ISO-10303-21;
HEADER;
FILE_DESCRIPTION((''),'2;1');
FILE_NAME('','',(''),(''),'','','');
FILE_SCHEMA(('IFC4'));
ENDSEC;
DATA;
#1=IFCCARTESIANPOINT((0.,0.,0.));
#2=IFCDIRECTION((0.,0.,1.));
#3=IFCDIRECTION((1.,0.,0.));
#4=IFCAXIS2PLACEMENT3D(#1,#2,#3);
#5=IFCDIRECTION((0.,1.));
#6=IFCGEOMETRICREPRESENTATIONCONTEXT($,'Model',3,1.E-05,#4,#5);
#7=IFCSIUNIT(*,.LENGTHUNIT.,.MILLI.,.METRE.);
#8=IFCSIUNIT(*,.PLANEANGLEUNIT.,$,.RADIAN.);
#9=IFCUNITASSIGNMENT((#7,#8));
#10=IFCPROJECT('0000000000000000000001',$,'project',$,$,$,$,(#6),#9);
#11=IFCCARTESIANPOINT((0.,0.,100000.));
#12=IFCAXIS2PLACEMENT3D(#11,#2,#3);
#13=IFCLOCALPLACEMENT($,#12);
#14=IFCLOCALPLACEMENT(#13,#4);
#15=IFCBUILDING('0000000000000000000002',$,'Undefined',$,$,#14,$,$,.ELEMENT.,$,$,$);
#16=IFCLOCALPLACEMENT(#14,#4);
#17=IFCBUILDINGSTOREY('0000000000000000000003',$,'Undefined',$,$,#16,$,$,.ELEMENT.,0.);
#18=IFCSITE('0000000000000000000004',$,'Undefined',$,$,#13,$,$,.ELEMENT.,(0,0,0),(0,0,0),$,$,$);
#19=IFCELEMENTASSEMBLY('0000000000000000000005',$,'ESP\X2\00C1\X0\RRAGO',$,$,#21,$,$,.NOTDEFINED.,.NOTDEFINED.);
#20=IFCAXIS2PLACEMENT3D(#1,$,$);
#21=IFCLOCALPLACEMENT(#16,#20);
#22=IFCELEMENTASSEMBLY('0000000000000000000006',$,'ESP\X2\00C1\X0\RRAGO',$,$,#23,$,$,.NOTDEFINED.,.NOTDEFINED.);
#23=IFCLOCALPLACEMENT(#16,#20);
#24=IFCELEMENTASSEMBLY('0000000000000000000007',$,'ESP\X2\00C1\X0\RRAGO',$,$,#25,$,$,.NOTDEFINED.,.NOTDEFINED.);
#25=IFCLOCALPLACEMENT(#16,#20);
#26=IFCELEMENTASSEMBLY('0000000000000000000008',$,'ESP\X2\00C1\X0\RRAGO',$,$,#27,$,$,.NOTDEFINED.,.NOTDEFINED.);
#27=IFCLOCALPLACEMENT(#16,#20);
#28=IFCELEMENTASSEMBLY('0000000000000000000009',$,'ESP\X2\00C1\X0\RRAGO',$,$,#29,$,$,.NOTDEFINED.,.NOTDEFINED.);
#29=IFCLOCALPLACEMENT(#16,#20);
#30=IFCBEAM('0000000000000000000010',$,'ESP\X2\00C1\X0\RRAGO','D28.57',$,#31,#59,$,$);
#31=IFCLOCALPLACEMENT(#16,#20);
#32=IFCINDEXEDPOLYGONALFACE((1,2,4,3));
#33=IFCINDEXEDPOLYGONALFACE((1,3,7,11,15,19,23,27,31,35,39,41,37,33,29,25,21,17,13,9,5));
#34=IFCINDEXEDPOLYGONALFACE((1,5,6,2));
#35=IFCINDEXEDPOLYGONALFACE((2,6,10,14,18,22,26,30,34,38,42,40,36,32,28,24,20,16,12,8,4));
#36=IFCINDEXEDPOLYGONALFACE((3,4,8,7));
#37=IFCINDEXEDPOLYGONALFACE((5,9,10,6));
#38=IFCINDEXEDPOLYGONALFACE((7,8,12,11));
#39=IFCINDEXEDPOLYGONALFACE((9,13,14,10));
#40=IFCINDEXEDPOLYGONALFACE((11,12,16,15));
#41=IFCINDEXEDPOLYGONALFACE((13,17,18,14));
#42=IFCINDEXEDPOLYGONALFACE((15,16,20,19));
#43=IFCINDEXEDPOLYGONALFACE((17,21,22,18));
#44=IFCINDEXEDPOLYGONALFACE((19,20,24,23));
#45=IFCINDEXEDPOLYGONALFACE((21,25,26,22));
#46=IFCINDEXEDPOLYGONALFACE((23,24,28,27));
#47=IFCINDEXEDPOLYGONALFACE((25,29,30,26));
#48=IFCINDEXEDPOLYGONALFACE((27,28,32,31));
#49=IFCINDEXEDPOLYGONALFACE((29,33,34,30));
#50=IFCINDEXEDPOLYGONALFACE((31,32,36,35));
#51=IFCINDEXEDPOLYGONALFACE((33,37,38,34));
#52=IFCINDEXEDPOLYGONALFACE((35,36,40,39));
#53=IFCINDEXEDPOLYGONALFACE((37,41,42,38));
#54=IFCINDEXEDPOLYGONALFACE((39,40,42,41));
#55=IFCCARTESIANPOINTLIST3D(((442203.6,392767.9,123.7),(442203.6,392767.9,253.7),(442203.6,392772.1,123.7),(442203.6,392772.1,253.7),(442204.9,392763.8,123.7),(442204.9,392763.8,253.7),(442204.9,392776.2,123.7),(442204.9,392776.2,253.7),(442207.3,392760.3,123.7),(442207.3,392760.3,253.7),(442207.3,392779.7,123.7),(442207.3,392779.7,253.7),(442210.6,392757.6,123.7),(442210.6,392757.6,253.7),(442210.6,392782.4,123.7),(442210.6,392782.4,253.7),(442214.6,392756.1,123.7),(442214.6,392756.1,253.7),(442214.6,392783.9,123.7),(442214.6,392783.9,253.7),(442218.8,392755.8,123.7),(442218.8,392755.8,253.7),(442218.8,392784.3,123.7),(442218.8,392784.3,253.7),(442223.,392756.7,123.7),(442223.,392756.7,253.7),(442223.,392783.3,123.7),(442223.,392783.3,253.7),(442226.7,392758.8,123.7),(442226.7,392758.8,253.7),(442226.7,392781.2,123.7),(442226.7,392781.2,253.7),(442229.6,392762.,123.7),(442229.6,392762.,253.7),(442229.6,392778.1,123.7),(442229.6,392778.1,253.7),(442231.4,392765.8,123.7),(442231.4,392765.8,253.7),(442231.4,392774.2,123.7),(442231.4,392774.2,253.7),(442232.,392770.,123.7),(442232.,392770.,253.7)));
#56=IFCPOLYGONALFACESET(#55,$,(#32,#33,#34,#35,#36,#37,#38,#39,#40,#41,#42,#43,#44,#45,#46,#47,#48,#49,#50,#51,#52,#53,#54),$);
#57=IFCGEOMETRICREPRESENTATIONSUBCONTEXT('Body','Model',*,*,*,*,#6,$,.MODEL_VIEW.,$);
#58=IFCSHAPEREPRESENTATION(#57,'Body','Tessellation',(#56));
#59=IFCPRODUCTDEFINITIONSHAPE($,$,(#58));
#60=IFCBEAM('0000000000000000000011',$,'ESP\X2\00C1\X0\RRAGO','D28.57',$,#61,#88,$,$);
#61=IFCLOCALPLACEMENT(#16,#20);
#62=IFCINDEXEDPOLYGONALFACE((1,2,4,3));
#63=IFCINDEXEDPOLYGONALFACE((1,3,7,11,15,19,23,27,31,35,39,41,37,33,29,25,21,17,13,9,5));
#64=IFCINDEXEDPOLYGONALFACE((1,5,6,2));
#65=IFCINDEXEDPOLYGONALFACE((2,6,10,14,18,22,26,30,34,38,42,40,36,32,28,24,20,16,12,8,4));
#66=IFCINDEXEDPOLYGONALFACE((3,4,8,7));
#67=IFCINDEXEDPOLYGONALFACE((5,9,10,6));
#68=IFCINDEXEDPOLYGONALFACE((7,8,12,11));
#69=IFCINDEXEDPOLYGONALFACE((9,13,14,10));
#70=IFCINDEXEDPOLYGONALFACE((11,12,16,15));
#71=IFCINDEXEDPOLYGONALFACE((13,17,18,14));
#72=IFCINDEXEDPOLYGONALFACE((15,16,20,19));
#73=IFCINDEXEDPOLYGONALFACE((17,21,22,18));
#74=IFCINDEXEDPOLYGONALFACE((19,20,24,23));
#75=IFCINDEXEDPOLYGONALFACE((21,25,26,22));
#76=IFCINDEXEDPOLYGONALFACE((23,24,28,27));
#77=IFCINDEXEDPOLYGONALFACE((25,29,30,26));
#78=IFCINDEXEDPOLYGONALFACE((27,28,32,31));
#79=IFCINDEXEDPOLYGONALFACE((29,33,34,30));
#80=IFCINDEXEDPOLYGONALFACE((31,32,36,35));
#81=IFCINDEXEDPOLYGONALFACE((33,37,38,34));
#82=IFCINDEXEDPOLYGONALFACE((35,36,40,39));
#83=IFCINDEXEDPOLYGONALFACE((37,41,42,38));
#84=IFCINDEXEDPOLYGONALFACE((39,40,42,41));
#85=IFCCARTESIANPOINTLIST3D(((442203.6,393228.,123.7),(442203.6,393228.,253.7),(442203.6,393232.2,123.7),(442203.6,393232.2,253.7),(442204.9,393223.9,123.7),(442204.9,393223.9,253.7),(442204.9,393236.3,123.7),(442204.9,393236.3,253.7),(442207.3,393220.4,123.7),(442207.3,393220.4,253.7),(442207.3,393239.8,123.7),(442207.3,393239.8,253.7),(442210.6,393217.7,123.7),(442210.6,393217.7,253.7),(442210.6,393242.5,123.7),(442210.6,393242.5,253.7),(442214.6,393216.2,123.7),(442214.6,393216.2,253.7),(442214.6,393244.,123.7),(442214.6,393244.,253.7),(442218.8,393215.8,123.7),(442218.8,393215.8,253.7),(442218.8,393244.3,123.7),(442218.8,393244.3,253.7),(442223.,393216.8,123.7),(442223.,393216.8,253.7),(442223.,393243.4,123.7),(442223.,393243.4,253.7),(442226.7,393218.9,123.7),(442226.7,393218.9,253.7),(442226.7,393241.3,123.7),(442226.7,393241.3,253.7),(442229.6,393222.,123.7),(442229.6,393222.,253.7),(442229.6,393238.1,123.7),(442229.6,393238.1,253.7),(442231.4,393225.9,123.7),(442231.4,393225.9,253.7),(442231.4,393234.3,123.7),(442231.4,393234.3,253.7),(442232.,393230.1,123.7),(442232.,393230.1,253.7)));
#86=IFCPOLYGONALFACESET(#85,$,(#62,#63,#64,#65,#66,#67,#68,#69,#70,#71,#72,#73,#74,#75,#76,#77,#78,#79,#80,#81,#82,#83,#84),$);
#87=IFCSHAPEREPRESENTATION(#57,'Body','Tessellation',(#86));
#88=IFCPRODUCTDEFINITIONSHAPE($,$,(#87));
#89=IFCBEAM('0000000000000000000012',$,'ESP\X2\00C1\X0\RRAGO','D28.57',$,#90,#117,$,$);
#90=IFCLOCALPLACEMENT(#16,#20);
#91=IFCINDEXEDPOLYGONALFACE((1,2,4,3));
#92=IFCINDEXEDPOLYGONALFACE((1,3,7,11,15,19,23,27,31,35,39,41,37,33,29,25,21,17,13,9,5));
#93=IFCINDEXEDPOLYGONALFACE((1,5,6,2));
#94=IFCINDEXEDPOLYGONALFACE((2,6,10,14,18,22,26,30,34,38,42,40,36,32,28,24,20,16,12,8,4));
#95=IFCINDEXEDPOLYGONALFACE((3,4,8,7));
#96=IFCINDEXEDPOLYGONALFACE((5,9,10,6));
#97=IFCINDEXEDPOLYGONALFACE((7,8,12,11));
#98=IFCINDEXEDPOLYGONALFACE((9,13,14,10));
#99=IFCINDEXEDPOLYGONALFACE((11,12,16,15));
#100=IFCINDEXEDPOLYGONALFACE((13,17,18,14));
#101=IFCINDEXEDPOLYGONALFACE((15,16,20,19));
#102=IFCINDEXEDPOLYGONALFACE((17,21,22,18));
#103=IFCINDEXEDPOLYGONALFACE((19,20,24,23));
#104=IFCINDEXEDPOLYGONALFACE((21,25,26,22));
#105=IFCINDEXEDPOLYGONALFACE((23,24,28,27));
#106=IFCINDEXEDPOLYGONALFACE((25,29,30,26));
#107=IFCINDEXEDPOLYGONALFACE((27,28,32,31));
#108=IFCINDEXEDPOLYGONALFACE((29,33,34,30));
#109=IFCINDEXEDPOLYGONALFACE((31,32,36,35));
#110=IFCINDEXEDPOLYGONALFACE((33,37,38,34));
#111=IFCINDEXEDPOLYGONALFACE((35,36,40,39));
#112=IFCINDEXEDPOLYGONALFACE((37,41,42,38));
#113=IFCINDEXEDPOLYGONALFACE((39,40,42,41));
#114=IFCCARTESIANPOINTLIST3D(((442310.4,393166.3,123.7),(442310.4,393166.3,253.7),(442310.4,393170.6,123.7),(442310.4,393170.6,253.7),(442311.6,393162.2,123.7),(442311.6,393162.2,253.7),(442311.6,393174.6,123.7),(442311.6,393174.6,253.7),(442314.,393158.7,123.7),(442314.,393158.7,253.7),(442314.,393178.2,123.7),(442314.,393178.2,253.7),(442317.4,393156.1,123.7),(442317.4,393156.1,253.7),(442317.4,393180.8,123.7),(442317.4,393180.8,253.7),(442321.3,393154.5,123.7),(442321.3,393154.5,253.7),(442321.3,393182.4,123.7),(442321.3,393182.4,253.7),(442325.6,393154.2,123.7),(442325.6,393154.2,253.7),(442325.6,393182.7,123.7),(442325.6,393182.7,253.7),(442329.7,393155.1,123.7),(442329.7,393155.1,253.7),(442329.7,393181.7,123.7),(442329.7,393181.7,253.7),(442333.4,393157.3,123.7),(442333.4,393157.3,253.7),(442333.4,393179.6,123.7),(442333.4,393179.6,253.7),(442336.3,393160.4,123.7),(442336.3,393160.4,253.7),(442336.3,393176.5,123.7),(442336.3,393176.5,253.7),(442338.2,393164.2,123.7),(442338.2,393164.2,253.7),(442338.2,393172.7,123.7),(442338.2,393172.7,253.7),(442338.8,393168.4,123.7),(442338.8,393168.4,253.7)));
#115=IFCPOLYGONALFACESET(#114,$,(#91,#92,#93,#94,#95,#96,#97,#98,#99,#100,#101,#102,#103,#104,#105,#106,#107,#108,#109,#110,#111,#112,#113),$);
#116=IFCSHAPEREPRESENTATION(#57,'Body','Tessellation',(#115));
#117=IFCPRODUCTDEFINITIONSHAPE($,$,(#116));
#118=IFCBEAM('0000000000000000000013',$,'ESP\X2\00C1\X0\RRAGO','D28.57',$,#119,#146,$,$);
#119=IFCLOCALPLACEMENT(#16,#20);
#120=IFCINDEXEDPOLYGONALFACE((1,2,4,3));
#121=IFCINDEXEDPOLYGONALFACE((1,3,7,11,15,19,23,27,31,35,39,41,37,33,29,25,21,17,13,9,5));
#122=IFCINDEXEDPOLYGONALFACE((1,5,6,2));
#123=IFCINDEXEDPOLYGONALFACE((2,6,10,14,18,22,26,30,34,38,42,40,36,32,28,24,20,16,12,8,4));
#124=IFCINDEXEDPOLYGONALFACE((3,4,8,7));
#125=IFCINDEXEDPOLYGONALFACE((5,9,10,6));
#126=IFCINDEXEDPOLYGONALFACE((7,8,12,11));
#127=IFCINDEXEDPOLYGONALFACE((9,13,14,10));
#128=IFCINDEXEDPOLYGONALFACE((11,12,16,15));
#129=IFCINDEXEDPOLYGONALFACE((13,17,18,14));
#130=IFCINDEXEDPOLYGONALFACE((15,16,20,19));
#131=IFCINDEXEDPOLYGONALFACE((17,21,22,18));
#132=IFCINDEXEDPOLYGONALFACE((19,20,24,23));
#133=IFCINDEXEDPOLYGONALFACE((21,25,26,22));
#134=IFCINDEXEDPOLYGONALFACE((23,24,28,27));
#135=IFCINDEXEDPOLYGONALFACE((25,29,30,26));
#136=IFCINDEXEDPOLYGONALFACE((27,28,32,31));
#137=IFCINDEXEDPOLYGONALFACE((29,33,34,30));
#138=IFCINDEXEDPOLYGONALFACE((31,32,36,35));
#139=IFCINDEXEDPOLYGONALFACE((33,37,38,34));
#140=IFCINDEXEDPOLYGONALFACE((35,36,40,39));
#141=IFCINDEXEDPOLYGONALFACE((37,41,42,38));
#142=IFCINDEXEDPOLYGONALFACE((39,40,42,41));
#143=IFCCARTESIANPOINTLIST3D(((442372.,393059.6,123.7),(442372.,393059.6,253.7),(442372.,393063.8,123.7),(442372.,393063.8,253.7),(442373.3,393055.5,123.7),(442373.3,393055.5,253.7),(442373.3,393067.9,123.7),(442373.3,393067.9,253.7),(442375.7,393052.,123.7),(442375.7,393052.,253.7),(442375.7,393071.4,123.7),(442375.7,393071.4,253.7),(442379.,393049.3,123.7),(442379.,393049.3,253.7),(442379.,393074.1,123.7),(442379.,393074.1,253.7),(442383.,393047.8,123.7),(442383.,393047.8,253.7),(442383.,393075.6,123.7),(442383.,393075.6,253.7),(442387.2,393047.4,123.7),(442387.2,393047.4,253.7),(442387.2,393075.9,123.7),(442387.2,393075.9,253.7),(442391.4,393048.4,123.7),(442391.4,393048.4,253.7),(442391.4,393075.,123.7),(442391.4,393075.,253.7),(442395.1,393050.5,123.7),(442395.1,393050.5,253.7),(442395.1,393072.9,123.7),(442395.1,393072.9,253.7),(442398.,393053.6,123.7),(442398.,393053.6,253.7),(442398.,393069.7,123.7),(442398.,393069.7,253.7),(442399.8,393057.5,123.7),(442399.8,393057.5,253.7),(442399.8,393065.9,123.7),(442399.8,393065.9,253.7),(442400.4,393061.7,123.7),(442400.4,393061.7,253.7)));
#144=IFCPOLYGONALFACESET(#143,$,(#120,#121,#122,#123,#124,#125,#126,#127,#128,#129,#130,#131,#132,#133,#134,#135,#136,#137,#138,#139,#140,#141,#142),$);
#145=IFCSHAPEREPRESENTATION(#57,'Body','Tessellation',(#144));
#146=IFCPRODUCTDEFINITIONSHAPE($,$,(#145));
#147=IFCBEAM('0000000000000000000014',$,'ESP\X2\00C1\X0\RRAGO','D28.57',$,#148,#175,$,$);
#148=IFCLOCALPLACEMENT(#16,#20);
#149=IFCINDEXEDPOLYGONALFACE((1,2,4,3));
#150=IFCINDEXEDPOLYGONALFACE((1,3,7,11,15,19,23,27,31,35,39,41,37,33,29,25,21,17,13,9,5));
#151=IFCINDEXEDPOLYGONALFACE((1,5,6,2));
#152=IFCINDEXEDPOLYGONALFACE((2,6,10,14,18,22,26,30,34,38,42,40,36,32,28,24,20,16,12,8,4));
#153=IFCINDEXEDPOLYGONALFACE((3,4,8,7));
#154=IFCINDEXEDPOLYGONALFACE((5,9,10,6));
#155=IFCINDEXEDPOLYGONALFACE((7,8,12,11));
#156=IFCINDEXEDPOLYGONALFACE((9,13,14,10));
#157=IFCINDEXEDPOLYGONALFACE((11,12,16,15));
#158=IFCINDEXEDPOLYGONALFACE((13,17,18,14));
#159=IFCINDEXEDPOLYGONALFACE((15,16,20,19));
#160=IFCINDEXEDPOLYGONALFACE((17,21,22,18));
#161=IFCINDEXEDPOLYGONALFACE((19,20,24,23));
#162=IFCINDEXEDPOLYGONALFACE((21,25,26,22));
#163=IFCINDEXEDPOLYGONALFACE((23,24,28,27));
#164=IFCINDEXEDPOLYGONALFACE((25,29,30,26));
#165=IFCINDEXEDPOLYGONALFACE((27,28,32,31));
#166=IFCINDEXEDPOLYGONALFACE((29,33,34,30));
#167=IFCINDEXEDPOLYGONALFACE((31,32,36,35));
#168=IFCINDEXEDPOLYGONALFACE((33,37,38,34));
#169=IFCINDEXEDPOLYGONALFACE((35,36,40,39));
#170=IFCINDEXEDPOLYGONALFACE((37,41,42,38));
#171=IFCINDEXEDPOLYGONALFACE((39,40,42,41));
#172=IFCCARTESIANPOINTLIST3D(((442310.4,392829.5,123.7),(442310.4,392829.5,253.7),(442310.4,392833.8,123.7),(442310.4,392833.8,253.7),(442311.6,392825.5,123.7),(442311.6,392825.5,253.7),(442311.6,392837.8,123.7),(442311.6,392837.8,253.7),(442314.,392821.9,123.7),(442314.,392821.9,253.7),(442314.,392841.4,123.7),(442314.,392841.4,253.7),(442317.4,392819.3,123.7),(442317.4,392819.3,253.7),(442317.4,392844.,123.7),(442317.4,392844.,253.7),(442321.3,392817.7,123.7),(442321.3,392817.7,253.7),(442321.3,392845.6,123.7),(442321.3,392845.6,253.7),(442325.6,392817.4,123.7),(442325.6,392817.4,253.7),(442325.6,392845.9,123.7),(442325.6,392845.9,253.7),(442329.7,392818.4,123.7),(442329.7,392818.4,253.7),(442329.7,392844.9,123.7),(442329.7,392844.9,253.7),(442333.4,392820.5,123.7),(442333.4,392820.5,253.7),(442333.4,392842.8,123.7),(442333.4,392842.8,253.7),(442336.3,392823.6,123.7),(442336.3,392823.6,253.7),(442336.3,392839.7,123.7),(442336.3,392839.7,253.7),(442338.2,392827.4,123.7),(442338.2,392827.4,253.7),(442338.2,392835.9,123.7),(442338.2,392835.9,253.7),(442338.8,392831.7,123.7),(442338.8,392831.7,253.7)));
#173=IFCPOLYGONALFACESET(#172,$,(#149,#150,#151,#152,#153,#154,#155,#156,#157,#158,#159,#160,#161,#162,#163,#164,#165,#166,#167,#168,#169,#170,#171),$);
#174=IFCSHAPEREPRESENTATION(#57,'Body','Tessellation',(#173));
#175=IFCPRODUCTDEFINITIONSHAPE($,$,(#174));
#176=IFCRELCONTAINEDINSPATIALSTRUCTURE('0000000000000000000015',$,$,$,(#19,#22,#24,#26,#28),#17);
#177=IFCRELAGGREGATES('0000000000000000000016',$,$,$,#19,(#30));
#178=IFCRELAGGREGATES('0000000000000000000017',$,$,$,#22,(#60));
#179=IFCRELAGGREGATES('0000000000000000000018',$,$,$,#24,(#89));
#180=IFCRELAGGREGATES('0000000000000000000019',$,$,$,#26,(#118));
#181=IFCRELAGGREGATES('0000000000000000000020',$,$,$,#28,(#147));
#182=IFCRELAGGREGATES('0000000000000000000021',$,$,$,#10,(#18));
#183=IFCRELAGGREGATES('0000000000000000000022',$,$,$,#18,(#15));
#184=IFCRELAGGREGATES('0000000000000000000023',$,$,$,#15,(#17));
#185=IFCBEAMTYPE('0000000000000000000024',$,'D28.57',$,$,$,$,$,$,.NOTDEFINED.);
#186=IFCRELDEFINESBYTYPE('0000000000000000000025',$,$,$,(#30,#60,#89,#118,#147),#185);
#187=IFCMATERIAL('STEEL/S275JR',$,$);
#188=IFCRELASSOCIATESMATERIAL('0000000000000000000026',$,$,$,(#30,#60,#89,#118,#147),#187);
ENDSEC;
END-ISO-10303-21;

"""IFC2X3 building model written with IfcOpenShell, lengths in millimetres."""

from ifc_helpers import new_model, si_unit, direction, frame, origin_with_axes, origin_2d_with_axis, place, context, subcontext, project, spatial, circle, extrude, material, type_object, element, aggregate, save


model = new_model("IFC2X3")

# Units and contexts
model_context = context("Model", 3, precision=1e-05, world=origin_with_axes(), true_north=direction((0.0, 1.0)))
body_context = subcontext(model_context, "Body", "Model", "MODEL_VIEW")
ifc_project = project(units=[si_unit("LENGTHUNIT", "METRE", prefix="MILLI"), si_unit("PLANEANGLEUNIT", "RADIAN")], contexts=[model_context])

# Site, building, storey
site_placement = place(None, frame((0.0, 0.0, 100000.0), z_axis=(0.0, 0.0, 1.0), x_axis=(1.0, 0.0, 0.0)))
site = spatial("IfcSite", under=ifc_project, at=site_placement, Name="Undefined", CompositionType="ELEMENT", RefLatitude=(0, 0, 0), RefLongitude=(0, 0, 0))
building_placement = place(site_placement, origin_with_axes())
building = spatial("IfcBuilding", under=site, at=building_placement, Name="Undefined", CompositionType="ELEMENT")
storey_placement = place(building_placement, origin_with_axes())
storey = spatial("IfcBuildingStorey", under=building, at=storey_placement, Name="Undefined", CompositionType="ELEMENT", Elevation=0.0)

# Element assemblies
assembly_1_placement = place(storey_placement, origin_with_axes())
assembly_1 = element("IfcElementAssembly", 1, at=assembly_1_placement, inside=storey, Name="ESPÁRRAGO", AssemblyPlace="NOTDEFINED", PredefinedType="NOTDEFINED")
ifc_material = material(Name="STEEL/S275JR")
assembly_2_placement = place(storey_placement, origin_with_axes())
assembly_2 = element("IfcElementAssembly", 2, at=assembly_2_placement, inside=storey, Name="ESPÁRRAGO", AssemblyPlace="NOTDEFINED", PredefinedType="NOTDEFINED")
assembly_3_placement = place(storey_placement, origin_with_axes())
assembly_3 = element("IfcElementAssembly", 3, at=assembly_3_placement, inside=storey, Name="ESPÁRRAGO", AssemblyPlace="NOTDEFINED", PredefinedType="NOTDEFINED")
assembly_4_placement = place(storey_placement, origin_with_axes())
assembly_4 = element("IfcElementAssembly", 4, at=assembly_4_placement, inside=storey, Name="ESPÁRRAGO", AssemblyPlace="NOTDEFINED", PredefinedType="NOTDEFINED")

# Element assembly
assembly_5_placement = place(storey_placement, origin_with_axes())
assembly_5 = element("IfcElementAssembly", 5, at=assembly_5_placement, inside=storey, Name="ESPÁRRAGO", AssemblyPlace="NOTDEFINED", PredefinedType="NOTDEFINED")

# Shared definitions
beam_type_1 = type_object("IfcBeamType", Name="D28.57", PredefinedType="NOTDEFINED")

# Beams
beam_1_placement = place(assembly_1_placement, frame((442217.8, 392770.0, 253.7), z_axis=(0.866025, -0.5, 0.0), x_axis=(0.0, 0.0, -1.0)))
beam_1 = element("IfcBeam", 6, at=beam_1_placement, type_object=beam_type_1, material=ifc_material, Name="ESPÁRRAGO", Description="D28.57", context=body_context, shape_type="SweptSolid", body=[
    extrude(circle(Radius=14.3, at=origin_2d_with_axis()), frame((130.0, 0.0, 0.0), z_axis=(-1.0, 0.0, 0.0), x_axis=(0.0, -1.0, 0.0)), (0.0, 0.0, 1.0), 130.0),
])
aggregate(assembly_1, [beam_1])
beam_2_placement = place(assembly_2_placement, frame((442217.8, 393230.1, 253.7), z_axis=(0.866025, -0.5, 0.0), x_axis=(0.0, 0.0, -1.0)))
beam_2 = element("IfcBeam", 7, at=beam_2_placement, type_object=beam_type_1, material=ifc_material, Name="ESPÁRRAGO", Description="D28.57", context=body_context, shape_type="SweptSolid", body=[
    extrude(circle(Radius=14.3, at=origin_2d_with_axis()), frame((130.0, 0.0, 0.0), z_axis=(-1.0, 0.0, 0.0), x_axis=(0.0, -1.0, 0.0)), (0.0, 0.0, 1.0), 130.0),
])
aggregate(assembly_2, [beam_2])
beam_3_placement = place(assembly_3_placement, frame((442324.5, 393168.4, 253.7), z_axis=(0.866025, -0.5, 0.0), x_axis=(0.0, 0.0, -1.0)))
beam_3 = element("IfcBeam", 8, at=beam_3_placement, type_object=beam_type_1, material=ifc_material, Name="ESPÁRRAGO", Description="D28.57", context=body_context, shape_type="SweptSolid", body=[
    extrude(circle(Radius=14.3, at=origin_2d_with_axis()), frame((130.0, 0.0, 0.0), z_axis=(-1.0, 0.0, 0.0), x_axis=(0.0, -1.0, 0.0)), (0.0, 0.0, 1.0), 130.0),
])
aggregate(assembly_3, [beam_3])
beam_4_placement = place(assembly_4_placement, frame((442386.2, 393061.7, 253.7), z_axis=(0.866025, -0.5, 0.0), x_axis=(0.0, 0.0, -1.0)))
beam_4 = element("IfcBeam", 9, at=beam_4_placement, type_object=beam_type_1, material=ifc_material, Name="ESPÁRRAGO", Description="D28.57", context=body_context, shape_type="SweptSolid", body=[
    extrude(circle(Radius=14.3, at=origin_2d_with_axis()), frame((130.0, 0.0, 0.0), z_axis=(-1.0, 0.0, 0.0), x_axis=(0.0, -1.0, 0.0)), (0.0, 0.0, 1.0), 130.0),
])
aggregate(assembly_4, [beam_4])
beam_5_placement = place(assembly_5_placement, frame((442324.5, 392831.7, 253.7), z_axis=(0.866025, -0.5, 0.0), x_axis=(0.0, 0.0, -1.0)))
beam_5 = element("IfcBeam", 10, at=beam_5_placement, type_object=beam_type_1, material=ifc_material, Name="ESPÁRRAGO", Description="D28.57", context=body_context, shape_type="SweptSolid", body=[
    extrude(circle(Radius=14.3, at=origin_2d_with_axis()), frame((130.0, 0.0, 0.0), z_axis=(-1.0, 0.0, 0.0), x_axis=(0.0, -1.0, 0.0)), (0.0, 0.0, 1.0), 130.0),
])
aggregate(assembly_5, [beam_5])

save(model, "model.ifc")
